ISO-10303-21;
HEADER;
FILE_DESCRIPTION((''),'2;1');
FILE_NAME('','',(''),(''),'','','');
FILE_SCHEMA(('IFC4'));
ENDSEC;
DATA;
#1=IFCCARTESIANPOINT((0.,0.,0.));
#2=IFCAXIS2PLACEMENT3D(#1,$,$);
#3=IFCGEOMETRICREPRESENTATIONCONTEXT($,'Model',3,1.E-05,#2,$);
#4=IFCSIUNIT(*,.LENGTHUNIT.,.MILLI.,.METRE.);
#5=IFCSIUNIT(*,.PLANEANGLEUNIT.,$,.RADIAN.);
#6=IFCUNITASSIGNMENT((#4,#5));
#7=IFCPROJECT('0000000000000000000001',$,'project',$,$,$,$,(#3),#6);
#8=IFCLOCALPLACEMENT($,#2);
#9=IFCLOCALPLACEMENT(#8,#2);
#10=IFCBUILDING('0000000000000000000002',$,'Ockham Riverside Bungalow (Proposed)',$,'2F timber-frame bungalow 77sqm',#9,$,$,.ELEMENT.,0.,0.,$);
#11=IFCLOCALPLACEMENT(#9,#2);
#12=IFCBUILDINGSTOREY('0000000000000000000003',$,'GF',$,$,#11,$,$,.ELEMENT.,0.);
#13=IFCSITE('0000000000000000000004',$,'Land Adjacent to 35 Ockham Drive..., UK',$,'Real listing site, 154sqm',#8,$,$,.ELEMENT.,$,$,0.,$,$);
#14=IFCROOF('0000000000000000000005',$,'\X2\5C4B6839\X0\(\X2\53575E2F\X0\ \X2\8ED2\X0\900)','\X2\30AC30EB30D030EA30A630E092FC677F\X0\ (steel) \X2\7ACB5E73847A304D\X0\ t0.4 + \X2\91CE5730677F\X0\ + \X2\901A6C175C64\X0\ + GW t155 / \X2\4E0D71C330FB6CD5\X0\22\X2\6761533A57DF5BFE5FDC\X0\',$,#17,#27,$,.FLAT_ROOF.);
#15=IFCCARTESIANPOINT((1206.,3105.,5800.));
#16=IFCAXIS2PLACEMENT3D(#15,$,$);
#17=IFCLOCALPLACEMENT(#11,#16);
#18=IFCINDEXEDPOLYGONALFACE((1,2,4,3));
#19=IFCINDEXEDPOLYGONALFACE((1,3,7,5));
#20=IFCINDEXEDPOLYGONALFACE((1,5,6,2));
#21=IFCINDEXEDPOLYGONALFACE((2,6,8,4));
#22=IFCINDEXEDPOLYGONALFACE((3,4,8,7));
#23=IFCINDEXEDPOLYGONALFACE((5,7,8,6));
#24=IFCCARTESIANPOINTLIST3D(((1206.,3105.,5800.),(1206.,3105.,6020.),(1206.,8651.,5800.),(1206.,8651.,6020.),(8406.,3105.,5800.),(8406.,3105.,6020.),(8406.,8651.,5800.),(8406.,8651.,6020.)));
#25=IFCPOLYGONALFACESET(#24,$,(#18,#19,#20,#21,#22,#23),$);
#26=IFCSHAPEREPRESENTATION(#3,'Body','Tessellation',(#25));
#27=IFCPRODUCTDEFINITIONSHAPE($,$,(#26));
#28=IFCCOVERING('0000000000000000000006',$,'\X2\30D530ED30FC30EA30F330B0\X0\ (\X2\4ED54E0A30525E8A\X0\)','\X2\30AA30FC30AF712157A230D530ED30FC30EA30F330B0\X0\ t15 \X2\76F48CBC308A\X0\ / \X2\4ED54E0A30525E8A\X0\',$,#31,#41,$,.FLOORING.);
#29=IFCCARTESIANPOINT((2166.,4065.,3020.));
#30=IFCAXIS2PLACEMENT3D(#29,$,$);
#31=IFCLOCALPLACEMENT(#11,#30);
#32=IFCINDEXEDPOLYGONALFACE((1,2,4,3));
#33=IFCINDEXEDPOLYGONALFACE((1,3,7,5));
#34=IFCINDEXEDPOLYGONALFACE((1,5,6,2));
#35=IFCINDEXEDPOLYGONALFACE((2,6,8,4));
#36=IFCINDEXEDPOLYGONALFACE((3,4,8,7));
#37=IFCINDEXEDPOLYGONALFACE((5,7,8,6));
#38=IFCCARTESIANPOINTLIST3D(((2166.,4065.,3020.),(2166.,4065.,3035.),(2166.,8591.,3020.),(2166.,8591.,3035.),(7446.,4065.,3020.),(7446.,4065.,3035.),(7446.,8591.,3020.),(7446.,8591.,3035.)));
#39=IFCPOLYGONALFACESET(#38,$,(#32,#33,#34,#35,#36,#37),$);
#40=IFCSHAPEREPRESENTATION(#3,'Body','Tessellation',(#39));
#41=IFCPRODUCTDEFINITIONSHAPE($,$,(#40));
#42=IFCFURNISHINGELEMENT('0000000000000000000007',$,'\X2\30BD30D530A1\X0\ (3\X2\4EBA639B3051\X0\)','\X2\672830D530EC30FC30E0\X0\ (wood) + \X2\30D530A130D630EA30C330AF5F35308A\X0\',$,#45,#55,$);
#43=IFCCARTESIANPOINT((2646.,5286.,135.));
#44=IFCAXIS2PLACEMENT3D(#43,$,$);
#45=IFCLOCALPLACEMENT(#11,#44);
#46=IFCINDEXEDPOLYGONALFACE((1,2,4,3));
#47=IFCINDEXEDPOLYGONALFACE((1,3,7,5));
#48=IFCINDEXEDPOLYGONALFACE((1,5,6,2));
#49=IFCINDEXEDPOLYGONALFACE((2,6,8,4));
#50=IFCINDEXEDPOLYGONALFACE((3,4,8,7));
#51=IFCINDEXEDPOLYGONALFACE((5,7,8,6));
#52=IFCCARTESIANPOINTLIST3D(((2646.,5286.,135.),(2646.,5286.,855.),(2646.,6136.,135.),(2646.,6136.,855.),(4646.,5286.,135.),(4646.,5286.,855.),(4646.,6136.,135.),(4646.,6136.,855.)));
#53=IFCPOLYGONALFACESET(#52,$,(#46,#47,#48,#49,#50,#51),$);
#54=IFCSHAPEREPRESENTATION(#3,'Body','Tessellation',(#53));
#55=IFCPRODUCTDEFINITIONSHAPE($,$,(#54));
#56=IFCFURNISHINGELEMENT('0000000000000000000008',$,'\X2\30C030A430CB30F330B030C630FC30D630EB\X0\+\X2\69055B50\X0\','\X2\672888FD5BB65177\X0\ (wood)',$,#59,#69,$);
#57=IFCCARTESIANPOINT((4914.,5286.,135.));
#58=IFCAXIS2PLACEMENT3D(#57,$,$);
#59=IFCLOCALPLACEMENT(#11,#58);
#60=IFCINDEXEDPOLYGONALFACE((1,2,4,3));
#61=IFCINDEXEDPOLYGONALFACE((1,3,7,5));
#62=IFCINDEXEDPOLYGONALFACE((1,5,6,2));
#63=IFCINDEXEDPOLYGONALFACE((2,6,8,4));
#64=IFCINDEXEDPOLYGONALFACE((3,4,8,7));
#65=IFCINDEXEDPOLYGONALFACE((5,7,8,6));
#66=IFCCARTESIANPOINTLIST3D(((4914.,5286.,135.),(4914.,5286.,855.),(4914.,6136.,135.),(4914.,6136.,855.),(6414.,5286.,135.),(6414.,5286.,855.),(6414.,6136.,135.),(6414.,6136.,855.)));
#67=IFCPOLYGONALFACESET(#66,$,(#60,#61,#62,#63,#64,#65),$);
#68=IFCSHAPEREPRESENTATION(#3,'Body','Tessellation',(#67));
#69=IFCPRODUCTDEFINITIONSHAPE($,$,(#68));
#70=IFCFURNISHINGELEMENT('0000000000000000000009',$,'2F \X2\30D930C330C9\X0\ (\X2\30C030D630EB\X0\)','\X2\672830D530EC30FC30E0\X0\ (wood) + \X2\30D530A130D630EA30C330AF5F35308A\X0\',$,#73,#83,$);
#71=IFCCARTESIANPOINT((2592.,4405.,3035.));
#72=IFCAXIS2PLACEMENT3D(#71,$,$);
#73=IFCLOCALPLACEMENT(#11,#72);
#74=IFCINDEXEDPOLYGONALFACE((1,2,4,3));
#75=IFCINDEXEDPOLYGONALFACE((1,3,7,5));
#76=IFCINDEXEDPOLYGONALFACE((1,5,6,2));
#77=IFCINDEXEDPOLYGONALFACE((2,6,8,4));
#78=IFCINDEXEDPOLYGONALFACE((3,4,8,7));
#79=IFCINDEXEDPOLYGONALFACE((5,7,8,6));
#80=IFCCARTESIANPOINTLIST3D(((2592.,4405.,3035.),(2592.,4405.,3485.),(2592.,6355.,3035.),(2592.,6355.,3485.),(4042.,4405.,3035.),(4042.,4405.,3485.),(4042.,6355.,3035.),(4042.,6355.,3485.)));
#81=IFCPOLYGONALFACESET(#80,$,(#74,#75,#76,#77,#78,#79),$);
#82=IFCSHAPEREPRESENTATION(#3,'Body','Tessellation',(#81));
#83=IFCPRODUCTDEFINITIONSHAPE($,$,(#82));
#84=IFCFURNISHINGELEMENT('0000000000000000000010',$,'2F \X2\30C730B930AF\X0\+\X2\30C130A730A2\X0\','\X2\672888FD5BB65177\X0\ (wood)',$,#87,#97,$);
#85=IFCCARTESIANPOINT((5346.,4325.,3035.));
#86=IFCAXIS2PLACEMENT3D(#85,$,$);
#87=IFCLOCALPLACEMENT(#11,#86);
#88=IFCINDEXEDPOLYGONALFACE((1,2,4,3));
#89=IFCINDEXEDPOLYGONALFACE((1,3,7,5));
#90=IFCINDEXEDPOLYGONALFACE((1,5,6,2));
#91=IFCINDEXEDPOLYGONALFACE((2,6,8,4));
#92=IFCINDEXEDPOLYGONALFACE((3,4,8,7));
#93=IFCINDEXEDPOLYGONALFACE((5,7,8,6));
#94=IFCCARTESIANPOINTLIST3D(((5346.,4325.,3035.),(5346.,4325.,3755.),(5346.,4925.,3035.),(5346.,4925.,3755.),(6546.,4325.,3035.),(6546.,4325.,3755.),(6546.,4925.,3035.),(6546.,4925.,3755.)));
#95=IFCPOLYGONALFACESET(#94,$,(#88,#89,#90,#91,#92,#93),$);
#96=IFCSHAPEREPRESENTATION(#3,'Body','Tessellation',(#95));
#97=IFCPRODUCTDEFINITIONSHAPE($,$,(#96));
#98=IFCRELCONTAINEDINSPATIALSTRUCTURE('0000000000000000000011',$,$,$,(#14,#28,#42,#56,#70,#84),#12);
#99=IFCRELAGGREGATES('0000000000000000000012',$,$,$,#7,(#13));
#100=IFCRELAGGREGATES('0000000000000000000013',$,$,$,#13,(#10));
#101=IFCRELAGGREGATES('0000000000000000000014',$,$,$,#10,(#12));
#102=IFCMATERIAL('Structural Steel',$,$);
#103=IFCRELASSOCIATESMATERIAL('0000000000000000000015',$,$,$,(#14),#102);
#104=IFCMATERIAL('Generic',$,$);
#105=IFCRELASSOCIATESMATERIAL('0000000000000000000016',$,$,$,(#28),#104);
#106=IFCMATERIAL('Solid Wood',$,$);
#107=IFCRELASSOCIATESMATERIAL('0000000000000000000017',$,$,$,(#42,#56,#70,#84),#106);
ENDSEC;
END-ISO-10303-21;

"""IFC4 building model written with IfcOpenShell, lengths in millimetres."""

from ifc_helpers import new_model, si_unit, frame, frame_2d, origin, place, context, project, spatial, rectangle, extrude, material, element, save


model = new_model("IFC4")

# Units and contexts
model_context = context("Model", 3, precision=1e-05, world=origin())
ifc_project = project(units=[si_unit("LENGTHUNIT", "METRE", prefix="MILLI"), si_unit("PLANEANGLEUNIT", "RADIAN")], contexts=[model_context])

# Site, building, storey
site_placement = place(None, origin())
site = spatial("IfcSite", under=ifc_project, at=site_placement, Name="Land Adjacent to 35 Ockham Drive..., UK", ObjectType="Real listing site, 154sqm", CompositionType="ELEMENT", RefElevation=0.0)
building_placement = place(site_placement, origin())
building = spatial("IfcBuilding", under=site, at=building_placement, Name="Ockham Riverside Bungalow (Proposed)", ObjectType="2F timber-frame bungalow 77sqm", CompositionType="ELEMENT", ElevationOfRefHeight=0.0, ElevationOfTerrain=0.0)
storey_placement = place(building_placement, origin())
storey = spatial("IfcBuildingStorey", under=building, at=storey_placement, Name="GF", CompositionType="ELEMENT", Elevation=0.0)

# Shared definitions
ifc_material_1 = material(Name="Solid Wood")

# Roof
ifc_material_2 = material(Name="Structural Steel")
for number, where, name in (
    (1, (1206.0, 3105.0, 5800.0), "屋根(南帯 軒900)"),
):
    element("IfcRoof", number, at=place(storey_placement, frame(where)), inside=storey, material=ifc_material_2, Name=name, Description="ガルバリウム鋼板 (steel) 立平葺き t0.4 + 野地板 + 通気層 + GW t155 / 不燃・法22条区域対応", PredefinedType="FLAT_ROOF", context=model_context, shape_type="SweptSolid", body=[
        extrude(rectangle(XDim=7200.0, YDim=5546.0, at=frame_2d((3600.0, 2773.0))), frame((1206.0, 3105.0, 5800.0)), (0.0, 0.0, 1.0), 220.0),
    ])

# Covering
ifc_material_3 = material(Name="Generic")
covering_placement = place(storey_placement, frame((2166.0, 4065.0, 3020.0)))
element("IfcCovering", 2, at=covering_placement, inside=storey, material=ifc_material_3, Name="フローリング (仕上げ床)", Description="オーク無垢フローリング t15 直貼り / 仕上げ床", PredefinedType="FLOORING", context=model_context, shape_type="SweptSolid", body=[
    extrude(rectangle(XDim=5280.0, YDim=4526.0, at=frame_2d((2640.0, 2263.0))), frame((2166.0, 4065.0, 3020.0)), (0.0, 0.0, 1.0), 15.0),
])

# Furnishing elements
furnishing_1_placement = place(storey_placement, frame((2646.0, 5286.0, 135.0)))
element("IfcFurnishingElement", 3, at=furnishing_1_placement, inside=storey, material=ifc_material_1, Name="ソファ (3人掛け)", Description="木フレーム (wood) + ファブリック張り", context=model_context, shape_type="SweptSolid", body=[
    extrude(rectangle(XDim=2000.0, YDim=850.0, at=frame_2d((1000.0, 425.0))), frame((2646.0, 5286.0, 135.0)), (0.0, 0.0, 1.0), 720.0),
])
furnishing_2_placement = place(storey_placement, frame((4914.0, 5286.0, 135.0)))
element("IfcFurnishingElement", 4, at=furnishing_2_placement, inside=storey, material=ifc_material_1, Name="ダイニングテーブル+椅子", Description="木製家具 (wood)", context=model_context, shape_type="SweptSolid", body=[
    extrude(rectangle(XDim=1500.0, YDim=850.0, at=frame_2d((750.0, 425.0))), frame((4914.0, 5286.0, 135.0)), (0.0, 0.0, 1.0), 720.0),
])
furnishing_3_placement = place(storey_placement, frame((2592.0, 4405.0, 3035.0)))
element("IfcFurnishingElement", 5, at=furnishing_3_placement, inside=storey, material=ifc_material_1, Name="2F ベッド (ダブル)", Description="木フレーム (wood) + ファブリック張り", context=model_context, shape_type="SweptSolid", body=[
    extrude(rectangle(XDim=1450.0, YDim=1950.0, at=frame_2d((725.0, 975.0))), frame((2592.0, 4405.0, 3035.0)), (0.0, 0.0, 1.0), 450.0),
])
furnishing_4_placement = place(storey_placement, frame((5346.0, 4325.0, 3035.0)))
element("IfcFurnishingElement", 6, at=furnishing_4_placement, inside=storey, material=ifc_material_1, Name="2F デスク+チェア", Description="木製家具 (wood)", context=model_context, shape_type="SweptSolid", body=[
    extrude(rectangle(XDim=1200.0, YDim=600.0, at=frame_2d((600.0, 300.0))), frame((5346.0, 4325.0, 3035.0)), (0.0, 0.0, 1.0), 720.0),
])

save(model, "model.ifc")
